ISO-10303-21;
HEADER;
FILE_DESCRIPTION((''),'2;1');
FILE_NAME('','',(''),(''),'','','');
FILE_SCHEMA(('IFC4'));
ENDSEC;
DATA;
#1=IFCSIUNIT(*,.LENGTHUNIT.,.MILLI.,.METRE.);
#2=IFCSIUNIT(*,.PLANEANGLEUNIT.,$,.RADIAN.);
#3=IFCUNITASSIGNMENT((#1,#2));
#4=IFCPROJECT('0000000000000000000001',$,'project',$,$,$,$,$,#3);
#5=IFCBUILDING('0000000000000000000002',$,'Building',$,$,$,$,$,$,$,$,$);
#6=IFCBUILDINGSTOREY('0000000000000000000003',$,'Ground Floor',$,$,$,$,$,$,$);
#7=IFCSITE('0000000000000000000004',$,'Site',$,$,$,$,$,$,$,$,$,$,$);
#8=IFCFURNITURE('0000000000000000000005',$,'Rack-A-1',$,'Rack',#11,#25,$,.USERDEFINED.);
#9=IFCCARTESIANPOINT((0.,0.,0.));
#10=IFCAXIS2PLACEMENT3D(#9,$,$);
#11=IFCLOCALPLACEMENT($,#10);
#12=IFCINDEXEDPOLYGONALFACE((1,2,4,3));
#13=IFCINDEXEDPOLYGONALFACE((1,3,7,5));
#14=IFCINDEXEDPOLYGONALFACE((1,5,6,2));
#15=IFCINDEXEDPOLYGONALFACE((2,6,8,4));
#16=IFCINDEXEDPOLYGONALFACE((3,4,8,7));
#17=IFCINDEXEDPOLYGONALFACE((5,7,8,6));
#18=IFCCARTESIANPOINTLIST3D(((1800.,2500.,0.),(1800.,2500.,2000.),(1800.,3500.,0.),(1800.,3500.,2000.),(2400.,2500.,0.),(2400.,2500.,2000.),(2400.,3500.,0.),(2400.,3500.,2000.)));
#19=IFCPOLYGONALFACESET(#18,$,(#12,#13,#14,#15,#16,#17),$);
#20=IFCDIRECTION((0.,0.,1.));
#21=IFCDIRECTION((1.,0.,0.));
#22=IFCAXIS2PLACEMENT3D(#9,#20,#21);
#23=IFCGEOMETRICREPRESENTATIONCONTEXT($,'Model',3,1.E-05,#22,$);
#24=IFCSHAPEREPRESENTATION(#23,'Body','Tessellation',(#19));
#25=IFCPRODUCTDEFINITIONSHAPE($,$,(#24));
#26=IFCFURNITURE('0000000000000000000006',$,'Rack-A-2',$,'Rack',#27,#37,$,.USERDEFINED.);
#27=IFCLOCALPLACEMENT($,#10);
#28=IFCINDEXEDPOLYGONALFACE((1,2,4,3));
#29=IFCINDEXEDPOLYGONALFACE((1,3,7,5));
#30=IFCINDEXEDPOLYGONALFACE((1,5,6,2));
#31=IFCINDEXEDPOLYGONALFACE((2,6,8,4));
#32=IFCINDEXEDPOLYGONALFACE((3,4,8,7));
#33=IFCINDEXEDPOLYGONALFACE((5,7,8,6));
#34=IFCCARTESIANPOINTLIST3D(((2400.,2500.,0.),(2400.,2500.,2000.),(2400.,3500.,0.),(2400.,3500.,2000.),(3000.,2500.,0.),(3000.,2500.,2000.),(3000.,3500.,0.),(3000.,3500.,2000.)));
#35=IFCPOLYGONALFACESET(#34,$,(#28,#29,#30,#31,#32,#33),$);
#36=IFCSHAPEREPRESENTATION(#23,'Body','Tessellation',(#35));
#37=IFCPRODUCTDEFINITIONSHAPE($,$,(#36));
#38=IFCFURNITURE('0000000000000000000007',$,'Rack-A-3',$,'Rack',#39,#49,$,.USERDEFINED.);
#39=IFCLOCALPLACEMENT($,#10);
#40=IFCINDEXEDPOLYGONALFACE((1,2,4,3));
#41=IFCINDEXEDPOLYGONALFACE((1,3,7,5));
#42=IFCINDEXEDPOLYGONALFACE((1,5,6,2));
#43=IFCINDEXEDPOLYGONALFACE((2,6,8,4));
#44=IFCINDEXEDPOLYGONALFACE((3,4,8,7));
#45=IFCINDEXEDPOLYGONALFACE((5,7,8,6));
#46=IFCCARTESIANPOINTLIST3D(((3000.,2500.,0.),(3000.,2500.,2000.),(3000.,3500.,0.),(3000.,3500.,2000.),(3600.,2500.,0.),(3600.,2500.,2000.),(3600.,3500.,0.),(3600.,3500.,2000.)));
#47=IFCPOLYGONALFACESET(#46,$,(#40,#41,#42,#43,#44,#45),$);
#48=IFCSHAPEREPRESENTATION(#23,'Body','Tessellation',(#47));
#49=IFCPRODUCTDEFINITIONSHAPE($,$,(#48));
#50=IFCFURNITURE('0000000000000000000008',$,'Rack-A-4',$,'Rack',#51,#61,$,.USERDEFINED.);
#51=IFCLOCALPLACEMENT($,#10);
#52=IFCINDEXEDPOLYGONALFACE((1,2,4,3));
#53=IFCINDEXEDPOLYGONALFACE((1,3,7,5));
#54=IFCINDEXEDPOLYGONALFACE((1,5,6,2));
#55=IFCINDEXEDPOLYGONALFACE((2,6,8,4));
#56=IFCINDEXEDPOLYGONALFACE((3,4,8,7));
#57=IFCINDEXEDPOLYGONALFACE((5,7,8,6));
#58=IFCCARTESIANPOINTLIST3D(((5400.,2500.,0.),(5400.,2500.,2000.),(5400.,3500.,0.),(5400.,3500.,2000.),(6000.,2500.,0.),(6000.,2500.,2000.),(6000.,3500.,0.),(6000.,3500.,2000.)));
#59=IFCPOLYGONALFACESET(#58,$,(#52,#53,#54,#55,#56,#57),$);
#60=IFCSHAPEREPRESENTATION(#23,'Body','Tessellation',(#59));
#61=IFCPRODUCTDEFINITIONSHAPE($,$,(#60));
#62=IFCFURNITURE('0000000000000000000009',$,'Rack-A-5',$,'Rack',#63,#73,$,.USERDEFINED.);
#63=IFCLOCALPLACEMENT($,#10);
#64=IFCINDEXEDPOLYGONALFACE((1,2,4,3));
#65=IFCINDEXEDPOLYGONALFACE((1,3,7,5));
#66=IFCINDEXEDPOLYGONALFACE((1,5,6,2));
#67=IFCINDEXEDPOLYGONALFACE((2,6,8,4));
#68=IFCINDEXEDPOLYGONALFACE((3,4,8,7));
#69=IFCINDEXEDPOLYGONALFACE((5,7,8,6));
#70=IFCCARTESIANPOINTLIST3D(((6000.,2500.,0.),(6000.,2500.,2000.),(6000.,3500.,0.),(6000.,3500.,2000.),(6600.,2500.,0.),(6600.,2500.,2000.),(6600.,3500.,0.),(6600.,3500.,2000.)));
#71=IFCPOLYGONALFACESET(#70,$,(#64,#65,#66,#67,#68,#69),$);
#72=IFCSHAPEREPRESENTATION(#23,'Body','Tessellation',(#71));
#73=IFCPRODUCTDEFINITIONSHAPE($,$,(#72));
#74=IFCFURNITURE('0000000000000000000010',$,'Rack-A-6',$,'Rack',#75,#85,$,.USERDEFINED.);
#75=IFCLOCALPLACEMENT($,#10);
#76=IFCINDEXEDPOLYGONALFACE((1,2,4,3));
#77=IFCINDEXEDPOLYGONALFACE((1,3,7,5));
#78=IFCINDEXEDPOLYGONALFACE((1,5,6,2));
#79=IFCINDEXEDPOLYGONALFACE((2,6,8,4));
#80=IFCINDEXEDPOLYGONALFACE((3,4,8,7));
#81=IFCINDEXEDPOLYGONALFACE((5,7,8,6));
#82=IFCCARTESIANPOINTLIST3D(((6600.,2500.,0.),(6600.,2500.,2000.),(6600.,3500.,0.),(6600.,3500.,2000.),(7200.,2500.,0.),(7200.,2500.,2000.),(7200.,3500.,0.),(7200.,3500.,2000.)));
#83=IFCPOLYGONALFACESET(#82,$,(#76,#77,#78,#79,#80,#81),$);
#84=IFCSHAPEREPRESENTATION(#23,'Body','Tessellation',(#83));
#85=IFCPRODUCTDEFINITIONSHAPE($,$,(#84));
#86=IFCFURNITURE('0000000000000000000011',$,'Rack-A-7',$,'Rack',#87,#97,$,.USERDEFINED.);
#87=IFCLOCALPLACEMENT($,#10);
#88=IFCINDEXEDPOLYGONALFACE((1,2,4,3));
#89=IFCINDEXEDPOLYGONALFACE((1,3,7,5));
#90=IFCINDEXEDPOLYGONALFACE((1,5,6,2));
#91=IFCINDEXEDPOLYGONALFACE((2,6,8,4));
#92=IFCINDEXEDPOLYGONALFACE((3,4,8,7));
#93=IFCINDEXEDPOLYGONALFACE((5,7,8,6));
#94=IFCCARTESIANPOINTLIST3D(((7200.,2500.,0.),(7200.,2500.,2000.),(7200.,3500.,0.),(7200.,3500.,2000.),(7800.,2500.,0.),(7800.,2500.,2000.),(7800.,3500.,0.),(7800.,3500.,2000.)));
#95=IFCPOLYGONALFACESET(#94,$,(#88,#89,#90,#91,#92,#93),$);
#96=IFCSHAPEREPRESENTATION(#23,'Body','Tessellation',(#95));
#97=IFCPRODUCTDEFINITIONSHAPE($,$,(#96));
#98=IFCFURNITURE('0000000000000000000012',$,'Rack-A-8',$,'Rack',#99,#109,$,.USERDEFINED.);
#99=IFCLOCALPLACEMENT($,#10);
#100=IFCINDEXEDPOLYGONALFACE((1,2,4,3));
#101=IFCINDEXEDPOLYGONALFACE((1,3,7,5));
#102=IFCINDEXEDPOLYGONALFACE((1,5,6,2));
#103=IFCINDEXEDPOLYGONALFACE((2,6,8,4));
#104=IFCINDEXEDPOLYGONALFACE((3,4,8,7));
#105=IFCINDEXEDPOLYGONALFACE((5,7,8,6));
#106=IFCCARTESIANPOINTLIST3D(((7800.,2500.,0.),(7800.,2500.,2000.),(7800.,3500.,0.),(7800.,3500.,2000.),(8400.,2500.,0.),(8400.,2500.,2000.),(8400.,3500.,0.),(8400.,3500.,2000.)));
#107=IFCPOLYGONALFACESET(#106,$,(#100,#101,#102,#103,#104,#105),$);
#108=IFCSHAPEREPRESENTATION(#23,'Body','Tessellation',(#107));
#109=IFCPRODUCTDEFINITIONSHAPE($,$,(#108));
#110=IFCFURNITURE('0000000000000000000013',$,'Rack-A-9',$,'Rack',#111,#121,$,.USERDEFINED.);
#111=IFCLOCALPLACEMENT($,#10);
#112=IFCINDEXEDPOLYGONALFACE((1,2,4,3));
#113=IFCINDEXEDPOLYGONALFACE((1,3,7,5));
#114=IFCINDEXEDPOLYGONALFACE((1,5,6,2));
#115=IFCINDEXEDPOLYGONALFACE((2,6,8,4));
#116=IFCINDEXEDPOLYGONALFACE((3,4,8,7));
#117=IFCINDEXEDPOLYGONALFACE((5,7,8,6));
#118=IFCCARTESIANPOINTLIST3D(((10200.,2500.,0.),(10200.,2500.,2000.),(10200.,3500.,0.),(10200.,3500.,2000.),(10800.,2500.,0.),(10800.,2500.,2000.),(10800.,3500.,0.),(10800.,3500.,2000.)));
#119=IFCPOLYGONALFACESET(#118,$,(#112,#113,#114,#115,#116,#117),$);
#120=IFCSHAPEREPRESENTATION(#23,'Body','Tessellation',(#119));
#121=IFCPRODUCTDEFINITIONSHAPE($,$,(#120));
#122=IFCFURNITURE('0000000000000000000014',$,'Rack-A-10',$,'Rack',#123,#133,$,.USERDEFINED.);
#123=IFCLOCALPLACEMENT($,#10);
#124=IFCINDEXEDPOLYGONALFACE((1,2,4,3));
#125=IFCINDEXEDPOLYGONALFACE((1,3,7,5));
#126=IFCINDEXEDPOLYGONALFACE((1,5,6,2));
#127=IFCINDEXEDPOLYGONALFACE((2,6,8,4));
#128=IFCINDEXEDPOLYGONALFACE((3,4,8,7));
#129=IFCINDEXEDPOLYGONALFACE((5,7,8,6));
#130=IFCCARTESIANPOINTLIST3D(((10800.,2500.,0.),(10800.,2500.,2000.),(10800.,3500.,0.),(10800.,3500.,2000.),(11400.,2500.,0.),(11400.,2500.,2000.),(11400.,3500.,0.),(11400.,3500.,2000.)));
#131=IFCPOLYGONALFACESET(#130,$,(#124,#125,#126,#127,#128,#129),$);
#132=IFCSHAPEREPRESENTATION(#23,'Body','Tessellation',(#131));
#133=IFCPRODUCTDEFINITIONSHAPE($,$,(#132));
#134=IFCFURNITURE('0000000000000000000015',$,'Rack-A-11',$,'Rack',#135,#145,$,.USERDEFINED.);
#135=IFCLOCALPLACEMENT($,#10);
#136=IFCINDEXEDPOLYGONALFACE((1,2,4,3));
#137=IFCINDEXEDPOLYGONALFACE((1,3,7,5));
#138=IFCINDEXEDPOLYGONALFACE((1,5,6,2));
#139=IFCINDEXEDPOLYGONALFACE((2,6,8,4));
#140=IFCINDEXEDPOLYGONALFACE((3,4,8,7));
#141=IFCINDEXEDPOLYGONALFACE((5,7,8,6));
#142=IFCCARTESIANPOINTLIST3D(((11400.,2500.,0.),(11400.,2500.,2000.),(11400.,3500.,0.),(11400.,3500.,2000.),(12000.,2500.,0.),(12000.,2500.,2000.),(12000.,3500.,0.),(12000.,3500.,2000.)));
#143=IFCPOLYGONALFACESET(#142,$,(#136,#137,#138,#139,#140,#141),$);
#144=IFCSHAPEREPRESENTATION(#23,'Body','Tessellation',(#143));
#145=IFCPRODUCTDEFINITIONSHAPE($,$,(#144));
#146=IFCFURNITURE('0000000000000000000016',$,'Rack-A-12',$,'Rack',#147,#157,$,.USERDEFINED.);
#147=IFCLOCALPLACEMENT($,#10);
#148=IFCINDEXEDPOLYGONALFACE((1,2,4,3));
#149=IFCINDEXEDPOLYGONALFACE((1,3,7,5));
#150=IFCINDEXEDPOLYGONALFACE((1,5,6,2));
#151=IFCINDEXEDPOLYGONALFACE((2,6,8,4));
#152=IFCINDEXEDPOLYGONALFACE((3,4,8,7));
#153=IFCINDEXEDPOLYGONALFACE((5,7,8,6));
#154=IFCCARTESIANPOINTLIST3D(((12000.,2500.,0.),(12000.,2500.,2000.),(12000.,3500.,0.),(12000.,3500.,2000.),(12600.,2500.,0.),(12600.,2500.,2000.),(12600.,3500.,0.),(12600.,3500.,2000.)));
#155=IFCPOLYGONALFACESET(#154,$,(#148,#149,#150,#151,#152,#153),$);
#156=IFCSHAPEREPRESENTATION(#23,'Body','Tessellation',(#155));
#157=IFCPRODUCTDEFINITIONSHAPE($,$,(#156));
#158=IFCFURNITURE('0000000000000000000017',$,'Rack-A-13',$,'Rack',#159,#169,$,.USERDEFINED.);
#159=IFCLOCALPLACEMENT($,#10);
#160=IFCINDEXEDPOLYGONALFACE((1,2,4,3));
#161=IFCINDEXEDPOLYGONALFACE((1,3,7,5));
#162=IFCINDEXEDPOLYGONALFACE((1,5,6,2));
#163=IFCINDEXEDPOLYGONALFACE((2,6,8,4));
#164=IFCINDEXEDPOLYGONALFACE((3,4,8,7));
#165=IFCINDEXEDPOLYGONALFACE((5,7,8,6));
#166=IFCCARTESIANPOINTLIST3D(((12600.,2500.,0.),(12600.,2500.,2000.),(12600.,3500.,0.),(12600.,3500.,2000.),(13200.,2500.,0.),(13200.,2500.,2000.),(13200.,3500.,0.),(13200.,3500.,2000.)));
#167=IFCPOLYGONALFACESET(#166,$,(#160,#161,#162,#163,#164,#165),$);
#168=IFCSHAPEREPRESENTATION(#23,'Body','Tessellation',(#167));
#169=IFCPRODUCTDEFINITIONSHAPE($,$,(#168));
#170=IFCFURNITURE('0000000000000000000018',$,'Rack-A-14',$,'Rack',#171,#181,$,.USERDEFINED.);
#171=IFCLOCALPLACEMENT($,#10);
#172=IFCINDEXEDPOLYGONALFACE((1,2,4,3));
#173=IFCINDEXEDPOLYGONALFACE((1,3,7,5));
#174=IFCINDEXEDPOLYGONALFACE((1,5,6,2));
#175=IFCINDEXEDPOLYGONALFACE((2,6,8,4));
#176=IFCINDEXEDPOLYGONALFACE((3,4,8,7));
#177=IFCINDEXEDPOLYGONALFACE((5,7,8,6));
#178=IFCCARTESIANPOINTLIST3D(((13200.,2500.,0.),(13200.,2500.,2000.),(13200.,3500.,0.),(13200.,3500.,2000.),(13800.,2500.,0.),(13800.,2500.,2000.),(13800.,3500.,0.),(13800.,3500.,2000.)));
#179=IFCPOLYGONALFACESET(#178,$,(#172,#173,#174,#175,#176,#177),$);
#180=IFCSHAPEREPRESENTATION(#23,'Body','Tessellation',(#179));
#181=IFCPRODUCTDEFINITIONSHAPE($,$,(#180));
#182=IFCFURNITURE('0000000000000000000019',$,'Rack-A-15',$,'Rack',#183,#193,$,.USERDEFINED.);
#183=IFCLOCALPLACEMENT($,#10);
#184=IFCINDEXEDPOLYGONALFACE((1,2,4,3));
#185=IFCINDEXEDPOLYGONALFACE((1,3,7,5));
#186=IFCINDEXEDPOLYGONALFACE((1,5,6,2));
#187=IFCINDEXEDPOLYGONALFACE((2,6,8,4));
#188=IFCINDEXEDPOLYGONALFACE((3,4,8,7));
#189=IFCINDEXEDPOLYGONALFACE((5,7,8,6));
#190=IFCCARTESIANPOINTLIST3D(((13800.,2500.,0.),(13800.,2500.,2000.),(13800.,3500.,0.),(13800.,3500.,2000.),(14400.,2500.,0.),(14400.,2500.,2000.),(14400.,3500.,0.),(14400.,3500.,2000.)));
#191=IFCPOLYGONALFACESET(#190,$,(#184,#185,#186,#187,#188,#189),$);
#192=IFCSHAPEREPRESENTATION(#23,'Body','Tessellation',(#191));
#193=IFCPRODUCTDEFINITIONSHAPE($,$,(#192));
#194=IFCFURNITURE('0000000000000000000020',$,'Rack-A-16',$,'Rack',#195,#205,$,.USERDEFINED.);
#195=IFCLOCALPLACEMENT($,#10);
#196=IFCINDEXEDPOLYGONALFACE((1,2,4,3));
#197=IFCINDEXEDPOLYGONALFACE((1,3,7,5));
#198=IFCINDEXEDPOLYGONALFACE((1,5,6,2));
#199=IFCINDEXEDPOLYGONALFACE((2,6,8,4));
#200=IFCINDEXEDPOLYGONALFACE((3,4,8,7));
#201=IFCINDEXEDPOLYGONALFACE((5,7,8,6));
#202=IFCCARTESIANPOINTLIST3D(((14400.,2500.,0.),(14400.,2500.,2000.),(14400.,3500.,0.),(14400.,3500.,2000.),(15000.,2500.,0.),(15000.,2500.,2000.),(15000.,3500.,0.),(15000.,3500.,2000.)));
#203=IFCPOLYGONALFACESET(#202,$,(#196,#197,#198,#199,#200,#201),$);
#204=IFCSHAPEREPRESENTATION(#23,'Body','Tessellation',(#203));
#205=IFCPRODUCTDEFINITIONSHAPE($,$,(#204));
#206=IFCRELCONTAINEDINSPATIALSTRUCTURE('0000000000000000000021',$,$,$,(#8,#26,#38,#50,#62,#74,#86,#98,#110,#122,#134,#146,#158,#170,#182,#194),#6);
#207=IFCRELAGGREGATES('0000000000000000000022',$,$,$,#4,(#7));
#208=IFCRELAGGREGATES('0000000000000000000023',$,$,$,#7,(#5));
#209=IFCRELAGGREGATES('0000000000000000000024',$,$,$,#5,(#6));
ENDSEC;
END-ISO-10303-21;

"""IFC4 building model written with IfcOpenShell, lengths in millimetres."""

from ifc_helpers import new_model, si_unit, frame, origin_with_axes, place, context, project, spatial, rectangle, extrude, element, save


model = new_model("IFC4")

# Units and contexts
model_context = context("Model", 3, precision=1e-05, world=origin_with_axes())
ifc_project = project(units=[si_unit("LENGTHUNIT", "METRE", prefix="MILLI"), si_unit("PLANEANGLEUNIT", "RADIAN")])

# Site, building, storey
site = spatial("IfcSite", under=ifc_project, Name="Site")
building = spatial("IfcBuilding", under=site, Name="Building")
storey = spatial("IfcBuildingStorey", under=building, Name="Ground Floor")

# Furniture
furniture_1_placement = place(None, origin_with_axes())
element("IfcFurniture", 1, at=furniture_1_placement, inside=storey, Name="Rack-A-1", ObjectType="Rack", PredefinedType="USERDEFINED", context=model_context, shape_type="SweptSolid", body=[
    extrude(rectangle(XDim=600.0, YDim=1000.0), frame((2100.0, 3000.0, 0.0), z_axis=(0.0, 0.0, 1.0), x_axis=(1.0, 0.0, 0.0)), (0.0, 0.0, 1.0), 2000.0),
])
furniture_2_placement = place(None, origin_with_axes())
element("IfcFurniture", 2, at=furniture_2_placement, inside=storey, Name="Rack-A-2", ObjectType="Rack", PredefinedType="USERDEFINED", context=model_context, shape_type="SweptSolid", body=[
    extrude(rectangle(XDim=600.0, YDim=1000.0), frame((2700.0, 3000.0, 0.0), z_axis=(0.0, 0.0, 1.0), x_axis=(1.0, 0.0, 0.0)), (0.0, 0.0, 1.0), 2000.0),
])
furniture_3_placement = place(None, origin_with_axes())
element("IfcFurniture", 3, at=furniture_3_placement, inside=storey, Name="Rack-A-3", ObjectType="Rack", PredefinedType="USERDEFINED", context=model_context, shape_type="SweptSolid", body=[
    extrude(rectangle(XDim=600.0, YDim=1000.0), frame((3300.0, 3000.0, 0.0), z_axis=(0.0, 0.0, 1.0), x_axis=(1.0, 0.0, 0.0)), (0.0, 0.0, 1.0), 2000.0),
])
furniture_4_placement = place(None, origin_with_axes())
element("IfcFurniture", 4, at=furniture_4_placement, inside=storey, Name="Rack-A-4", ObjectType="Rack", PredefinedType="USERDEFINED", context=model_context, shape_type="SweptSolid", body=[
    extrude(rectangle(XDim=600.0, YDim=1000.0), frame((5700.0, 3000.0, 0.0), z_axis=(0.0, 0.0, 1.0), x_axis=(1.0, 0.0, 0.0)), (0.0, 0.0, 1.0), 2000.0),
])
furniture_5_placement = place(None, origin_with_axes())
element("IfcFurniture", 5, at=furniture_5_placement, inside=storey, Name="Rack-A-5", ObjectType="Rack", PredefinedType="USERDEFINED", context=model_context, shape_type="SweptSolid", body=[
    extrude(rectangle(XDim=600.0, YDim=1000.0), frame((6300.0, 3000.0, 0.0), z_axis=(0.0, 0.0, 1.0), x_axis=(1.0, 0.0, 0.0)), (0.0, 0.0, 1.0), 2000.0),
])
furniture_6_placement = place(None, origin_with_axes())
element("IfcFurniture", 6, at=furniture_6_placement, inside=storey, Name="Rack-A-6", ObjectType="Rack", PredefinedType="USERDEFINED", context=model_context, shape_type="SweptSolid", body=[
    extrude(rectangle(XDim=600.0, YDim=1000.0), frame((6900.0, 3000.0, 0.0), z_axis=(0.0, 0.0, 1.0), x_axis=(1.0, 0.0, 0.0)), (0.0, 0.0, 1.0), 2000.0),
])
furniture_7_placement = place(None, origin_with_axes())
element("IfcFurniture", 7, at=furniture_7_placement, inside=storey, Name="Rack-A-7", ObjectType="Rack", PredefinedType="USERDEFINED", context=model_context, shape_type="SweptSolid", body=[
    extrude(rectangle(XDim=600.0, YDim=1000.0), frame((7500.0, 3000.0, 0.0), z_axis=(0.0, 0.0, 1.0), x_axis=(1.0, 0.0, 0.0)), (0.0, 0.0, 1.0), 2000.0),
])
furniture_8_placement = place(None, origin_with_axes())
element("IfcFurniture", 8, at=furniture_8_placement, inside=storey, Name="Rack-A-8", ObjectType="Rack", PredefinedType="USERDEFINED", context=model_context, shape_type="SweptSolid", body=[
    extrude(rectangle(XDim=600.0, YDim=1000.0), frame((8100.0, 3000.0, 0.0), z_axis=(0.0, 0.0, 1.0), x_axis=(1.0, 0.0, 0.0)), (0.0, 0.0, 1.0), 2000.0),
])
furniture_9_placement = place(None, origin_with_axes())
element("IfcFurniture", 9, at=furniture_9_placement, inside=storey, Name="Rack-A-9", ObjectType="Rack", PredefinedType="USERDEFINED", context=model_context, shape_type="SweptSolid", body=[
    extrude(rectangle(XDim=600.0, YDim=1000.0), frame((10500.0, 3000.0, 0.0), z_axis=(0.0, 0.0, 1.0), x_axis=(1.0, 0.0, 0.0)), (0.0, 0.0, 1.0), 2000.0),
])
furniture_10_placement = place(None, origin_with_axes())
element("IfcFurniture", 10, at=furniture_10_placement, inside=storey, Name="Rack-A-10", ObjectType="Rack", PredefinedType="USERDEFINED", context=model_context, shape_type="SweptSolid", body=[
    extrude(rectangle(XDim=600.0, YDim=1000.0), frame((11100.0, 3000.0, 0.0), z_axis=(0.0, 0.0, 1.0), x_axis=(1.0, 0.0, 0.0)), (0.0, 0.0, 1.0), 2000.0),
])
furniture_11_placement = place(None, origin_with_axes())
element("IfcFurniture", 11, at=furniture_11_placement, inside=storey, Name="Rack-A-11", ObjectType="Rack", PredefinedType="USERDEFINED", context=model_context, shape_type="SweptSolid", body=[
    extrude(rectangle(XDim=600.0, YDim=1000.0), frame((11700.0, 3000.0, 0.0), z_axis=(0.0, 0.0, 1.0), x_axis=(1.0, 0.0, 0.0)), (0.0, 0.0, 1.0), 2000.0),
])
furniture_12_placement = place(None, origin_with_axes())
element("IfcFurniture", 12, at=furniture_12_placement, inside=storey, Name="Rack-A-12", ObjectType="Rack", PredefinedType="USERDEFINED", context=model_context, shape_type="SweptSolid", body=[
    extrude(rectangle(XDim=600.0, YDim=1000.0), frame((12300.0, 3000.0, 0.0), z_axis=(0.0, 0.0, 1.0), x_axis=(1.0, 0.0, 0.0)), (0.0, 0.0, 1.0), 2000.0),
])
furniture_13_placement = place(None, origin_with_axes())
element("IfcFurniture", 13, at=furniture_13_placement, inside=storey, Name="Rack-A-13", ObjectType="Rack", PredefinedType="USERDEFINED", context=model_context, shape_type="SweptSolid", body=[
    extrude(rectangle(XDim=600.0, YDim=1000.0), frame((12900.0, 3000.0, 0.0), z_axis=(0.0, 0.0, 1.0), x_axis=(1.0, 0.0, 0.0)), (0.0, 0.0, 1.0), 2000.0),
])
furniture_14_placement = place(None, origin_with_axes())
element("IfcFurniture", 14, at=furniture_14_placement, inside=storey, Name="Rack-A-14", ObjectType="Rack", PredefinedType="USERDEFINED", context=model_context, shape_type="SweptSolid", body=[
    extrude(rectangle(XDim=600.0, YDim=1000.0), frame((13500.0, 3000.0, 0.0), z_axis=(0.0, 0.0, 1.0), x_axis=(1.0, 0.0, 0.0)), (0.0, 0.0, 1.0), 2000.0),
])
furniture_15_placement = place(None, origin_with_axes())
element("IfcFurniture", 15, at=furniture_15_placement, inside=storey, Name="Rack-A-15", ObjectType="Rack", PredefinedType="USERDEFINED", context=model_context, shape_type="SweptSolid", body=[
    extrude(rectangle(XDim=600.0, YDim=1000.0), frame((14100.0, 3000.0, 0.0), z_axis=(0.0, 0.0, 1.0), x_axis=(1.0, 0.0, 0.0)), (0.0, 0.0, 1.0), 2000.0),
])
furniture_16_placement = place(None, origin_with_axes())
element("IfcFurniture", 16, at=furniture_16_placement, inside=storey, Name="Rack-A-16", ObjectType="Rack", PredefinedType="USERDEFINED", context=model_context, shape_type="SweptSolid", body=[
    extrude(rectangle(XDim=600.0, YDim=1000.0), frame((14700.0, 3000.0, 0.0), z_axis=(0.0, 0.0, 1.0), x_axis=(1.0, 0.0, 0.0)), (0.0, 0.0, 1.0), 2000.0),
])

save(model, "model.ifc")
